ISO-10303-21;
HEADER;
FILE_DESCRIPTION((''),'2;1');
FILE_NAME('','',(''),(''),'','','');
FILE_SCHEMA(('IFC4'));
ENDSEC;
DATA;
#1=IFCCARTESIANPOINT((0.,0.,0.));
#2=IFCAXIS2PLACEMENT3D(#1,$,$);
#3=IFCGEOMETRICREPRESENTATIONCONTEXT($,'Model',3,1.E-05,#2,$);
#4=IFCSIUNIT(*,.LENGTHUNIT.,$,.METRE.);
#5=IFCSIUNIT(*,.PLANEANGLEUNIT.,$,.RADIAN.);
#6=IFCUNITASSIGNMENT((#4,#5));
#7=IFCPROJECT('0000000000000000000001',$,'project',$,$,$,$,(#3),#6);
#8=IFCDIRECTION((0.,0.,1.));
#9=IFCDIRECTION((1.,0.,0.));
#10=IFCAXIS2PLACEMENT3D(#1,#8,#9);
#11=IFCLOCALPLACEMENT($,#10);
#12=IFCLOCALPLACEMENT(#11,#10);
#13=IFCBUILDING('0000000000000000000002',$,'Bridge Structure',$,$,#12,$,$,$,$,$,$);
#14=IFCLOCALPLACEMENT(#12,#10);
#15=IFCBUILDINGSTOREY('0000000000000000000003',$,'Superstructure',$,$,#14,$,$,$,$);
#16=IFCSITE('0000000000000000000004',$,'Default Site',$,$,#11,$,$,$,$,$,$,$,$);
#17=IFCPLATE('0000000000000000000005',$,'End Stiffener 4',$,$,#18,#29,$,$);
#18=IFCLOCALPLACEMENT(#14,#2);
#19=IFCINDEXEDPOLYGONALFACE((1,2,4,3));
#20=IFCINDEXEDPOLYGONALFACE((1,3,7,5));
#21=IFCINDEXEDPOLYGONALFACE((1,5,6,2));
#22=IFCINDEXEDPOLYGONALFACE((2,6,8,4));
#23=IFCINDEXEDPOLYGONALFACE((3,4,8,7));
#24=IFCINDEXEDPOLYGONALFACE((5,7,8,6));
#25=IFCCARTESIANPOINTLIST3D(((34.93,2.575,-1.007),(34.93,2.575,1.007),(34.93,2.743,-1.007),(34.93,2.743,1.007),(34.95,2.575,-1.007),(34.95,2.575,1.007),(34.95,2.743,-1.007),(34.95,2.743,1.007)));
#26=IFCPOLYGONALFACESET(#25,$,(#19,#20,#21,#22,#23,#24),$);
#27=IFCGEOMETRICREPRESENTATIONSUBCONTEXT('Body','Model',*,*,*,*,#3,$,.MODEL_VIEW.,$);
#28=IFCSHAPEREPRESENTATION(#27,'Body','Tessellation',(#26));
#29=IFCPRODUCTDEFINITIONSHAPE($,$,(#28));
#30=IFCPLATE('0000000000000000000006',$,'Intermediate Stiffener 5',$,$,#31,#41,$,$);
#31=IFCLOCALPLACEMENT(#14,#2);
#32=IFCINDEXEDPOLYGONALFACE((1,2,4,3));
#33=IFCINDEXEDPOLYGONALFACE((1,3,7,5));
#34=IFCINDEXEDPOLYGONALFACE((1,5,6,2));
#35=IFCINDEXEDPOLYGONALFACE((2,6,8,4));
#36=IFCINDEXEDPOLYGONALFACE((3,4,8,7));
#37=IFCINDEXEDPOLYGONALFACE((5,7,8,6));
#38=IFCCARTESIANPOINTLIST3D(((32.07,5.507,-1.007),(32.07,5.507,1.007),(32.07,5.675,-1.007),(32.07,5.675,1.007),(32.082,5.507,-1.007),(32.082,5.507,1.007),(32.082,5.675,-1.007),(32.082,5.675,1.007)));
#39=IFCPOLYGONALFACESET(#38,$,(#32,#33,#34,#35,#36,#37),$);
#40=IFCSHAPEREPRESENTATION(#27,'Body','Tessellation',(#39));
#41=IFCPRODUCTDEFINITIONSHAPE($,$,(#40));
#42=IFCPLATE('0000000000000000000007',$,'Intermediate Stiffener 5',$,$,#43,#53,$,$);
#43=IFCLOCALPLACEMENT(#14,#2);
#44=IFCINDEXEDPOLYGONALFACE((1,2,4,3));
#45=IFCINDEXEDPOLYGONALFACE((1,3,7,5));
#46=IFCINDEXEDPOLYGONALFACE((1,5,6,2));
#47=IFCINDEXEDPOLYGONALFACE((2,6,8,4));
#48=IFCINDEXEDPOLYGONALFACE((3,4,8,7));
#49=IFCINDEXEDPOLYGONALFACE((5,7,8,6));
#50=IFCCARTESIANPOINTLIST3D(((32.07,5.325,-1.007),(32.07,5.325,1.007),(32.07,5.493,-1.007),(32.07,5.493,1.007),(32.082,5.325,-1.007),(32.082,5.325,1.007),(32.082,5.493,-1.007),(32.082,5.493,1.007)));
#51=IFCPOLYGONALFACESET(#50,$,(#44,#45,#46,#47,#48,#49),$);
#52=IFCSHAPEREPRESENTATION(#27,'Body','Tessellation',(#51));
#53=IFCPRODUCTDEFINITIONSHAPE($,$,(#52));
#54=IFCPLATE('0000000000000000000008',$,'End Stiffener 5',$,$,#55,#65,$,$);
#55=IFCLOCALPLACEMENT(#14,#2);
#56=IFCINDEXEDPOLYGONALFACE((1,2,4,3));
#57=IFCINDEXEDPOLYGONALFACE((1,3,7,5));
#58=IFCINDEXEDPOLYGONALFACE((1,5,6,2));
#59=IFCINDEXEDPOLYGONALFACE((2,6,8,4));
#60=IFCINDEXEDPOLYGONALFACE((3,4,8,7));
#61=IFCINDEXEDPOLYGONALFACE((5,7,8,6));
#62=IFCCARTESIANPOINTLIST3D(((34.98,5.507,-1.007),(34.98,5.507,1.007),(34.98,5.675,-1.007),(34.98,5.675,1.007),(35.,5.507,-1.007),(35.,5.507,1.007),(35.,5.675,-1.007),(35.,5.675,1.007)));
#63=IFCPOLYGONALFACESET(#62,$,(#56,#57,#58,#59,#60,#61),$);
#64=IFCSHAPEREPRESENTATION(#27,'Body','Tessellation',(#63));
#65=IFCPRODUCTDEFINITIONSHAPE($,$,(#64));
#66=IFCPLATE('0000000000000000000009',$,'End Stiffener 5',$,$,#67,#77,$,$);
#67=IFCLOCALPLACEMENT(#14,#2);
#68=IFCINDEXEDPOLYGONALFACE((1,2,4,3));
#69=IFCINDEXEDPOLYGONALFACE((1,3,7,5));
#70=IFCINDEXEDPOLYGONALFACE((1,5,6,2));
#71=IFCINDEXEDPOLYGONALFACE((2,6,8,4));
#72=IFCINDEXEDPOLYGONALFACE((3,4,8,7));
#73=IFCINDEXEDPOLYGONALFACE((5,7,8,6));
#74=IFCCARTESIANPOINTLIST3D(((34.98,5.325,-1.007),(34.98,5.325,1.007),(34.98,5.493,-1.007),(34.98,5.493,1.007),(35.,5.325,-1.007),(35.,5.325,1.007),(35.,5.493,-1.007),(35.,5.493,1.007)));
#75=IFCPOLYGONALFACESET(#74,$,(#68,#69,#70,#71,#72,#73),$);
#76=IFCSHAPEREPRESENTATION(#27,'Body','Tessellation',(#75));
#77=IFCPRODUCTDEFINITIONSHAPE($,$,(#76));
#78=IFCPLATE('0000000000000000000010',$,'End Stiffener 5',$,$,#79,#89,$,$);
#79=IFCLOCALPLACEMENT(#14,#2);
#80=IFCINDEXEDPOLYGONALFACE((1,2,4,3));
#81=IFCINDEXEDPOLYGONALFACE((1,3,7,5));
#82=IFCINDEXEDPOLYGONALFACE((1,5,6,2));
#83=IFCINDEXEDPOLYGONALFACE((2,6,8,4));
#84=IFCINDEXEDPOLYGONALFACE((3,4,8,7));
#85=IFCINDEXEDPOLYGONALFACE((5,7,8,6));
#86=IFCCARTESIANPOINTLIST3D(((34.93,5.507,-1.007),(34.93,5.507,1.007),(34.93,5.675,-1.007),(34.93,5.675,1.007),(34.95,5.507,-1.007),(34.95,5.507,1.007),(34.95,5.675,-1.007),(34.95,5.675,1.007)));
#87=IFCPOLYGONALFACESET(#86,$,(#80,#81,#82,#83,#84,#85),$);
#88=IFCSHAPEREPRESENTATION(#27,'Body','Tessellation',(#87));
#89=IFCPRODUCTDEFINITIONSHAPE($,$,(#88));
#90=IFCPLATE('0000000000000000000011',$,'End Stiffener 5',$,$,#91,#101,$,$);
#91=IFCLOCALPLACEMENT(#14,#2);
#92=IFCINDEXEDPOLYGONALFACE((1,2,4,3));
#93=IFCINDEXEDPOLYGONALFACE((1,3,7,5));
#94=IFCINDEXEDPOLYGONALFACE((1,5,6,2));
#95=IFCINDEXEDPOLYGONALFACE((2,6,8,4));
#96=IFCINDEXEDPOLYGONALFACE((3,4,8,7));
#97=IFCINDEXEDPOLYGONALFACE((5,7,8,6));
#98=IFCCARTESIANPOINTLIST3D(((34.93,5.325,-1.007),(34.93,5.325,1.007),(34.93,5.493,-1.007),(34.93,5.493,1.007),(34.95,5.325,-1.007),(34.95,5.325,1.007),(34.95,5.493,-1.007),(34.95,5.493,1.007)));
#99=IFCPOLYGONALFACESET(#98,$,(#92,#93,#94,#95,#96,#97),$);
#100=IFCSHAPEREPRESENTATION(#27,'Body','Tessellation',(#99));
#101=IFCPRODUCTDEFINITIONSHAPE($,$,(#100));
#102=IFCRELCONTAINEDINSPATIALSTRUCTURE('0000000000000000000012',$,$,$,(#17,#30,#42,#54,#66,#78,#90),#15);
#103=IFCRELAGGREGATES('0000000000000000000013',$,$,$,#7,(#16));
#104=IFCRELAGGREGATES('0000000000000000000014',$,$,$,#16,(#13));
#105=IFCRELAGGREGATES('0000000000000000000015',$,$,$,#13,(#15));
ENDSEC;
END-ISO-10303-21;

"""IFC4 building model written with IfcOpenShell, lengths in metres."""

from ifc_helpers import new_model, si_unit, frame, origin, origin_with_axes, origin_2d_with_axis, place, context, subcontext, project, spatial, rectangle, extrude, element, save


model = new_model("IFC4")

# Units and contexts
model_context = context("Model", 3, precision=1e-05, world=origin())
body_context = subcontext(model_context, "Body", "Model", "MODEL_VIEW")
ifc_project = project(units=[si_unit("LENGTHUNIT", "METRE"), si_unit("PLANEANGLEUNIT", "RADIAN")], contexts=[model_context])

# Site, building, storey
site_placement = place(None, origin_with_axes())
site = spatial("IfcSite", under=ifc_project, at=site_placement, Name="Default Site")
building_placement = place(site_placement, origin_with_axes())
building = spatial("IfcBuilding", under=site, at=building_placement, Name="Bridge Structure")
storey_placement = place(building_placement, origin_with_axes())
storey = spatial("IfcBuildingStorey", under=building, at=storey_placement, Name="Superstructure")

# Plates
for number, where, z_axis, x_axis, name in (
    (1, (34.94, 2.659, -1.007), (0.0, 0.0, 1.0), (1.0, 0.0, 0.0), "End Stiffener 4"),
):
    element("IfcPlate", number, at=place(storey_placement, frame(where, z_axis=z_axis, x_axis=x_axis)), inside=storey, Name=name, context=body_context, shape_type="SweptSolid", body=[
        extrude(rectangle(XDim=0.02, YDim=0.168, at=origin_2d_with_axis()), origin_with_axes(), (0.0, 0.0, 1.0), 2.014),
    ])
for number, where, z_axis, x_axis, name in (
    (2, (32.076, 5.591, -1.007), (0.0, 0.0, 1.0), (1.0, 0.0, 0.0), "Intermediate Stiffener 5"),
    (3, (32.076, 5.409, -1.007), (0.0, 0.0, 1.0), (1.0, 0.0, 0.0), "Intermediate Stiffener 5"),
):
    element("IfcPlate", number, at=place(storey_placement, frame(where, z_axis=z_axis, x_axis=x_axis)), inside=storey, Name=name, context=body_context, shape_type="SweptSolid", body=[
        extrude(rectangle(XDim=0.012, YDim=0.168, at=origin_2d_with_axis()), origin_with_axes(), (0.0, 0.0, 1.0), 2.014),
    ])
for number, where, z_axis, x_axis, name in (
    (4, (34.99, 5.591, -1.007), (0.0, 0.0, 1.0), (1.0, 0.0, 0.0), "End Stiffener 5"),
    (5, (34.99, 5.409, -1.007), (0.0, 0.0, 1.0), (1.0, 0.0, 0.0), "End Stiffener 5"),
    (6, (34.94, 5.591, -1.007), (0.0, 0.0, 1.0), (1.0, 0.0, 0.0), "End Stiffener 5"),
    (7, (34.94, 5.409, -1.007), (0.0, 0.0, 1.0), (1.0, 0.0, 0.0), "End Stiffener 5"),
):
    element("IfcPlate", number, at=place(storey_placement, frame(where, z_axis=z_axis, x_axis=x_axis)), inside=storey, Name=name, context=body_context, shape_type="SweptSolid", body=[
        extrude(rectangle(XDim=0.02, YDim=0.168, at=origin_2d_with_axis()), origin_with_axes(), (0.0, 0.0, 1.0), 2.014),
    ])

save(model, "model.ifc")
